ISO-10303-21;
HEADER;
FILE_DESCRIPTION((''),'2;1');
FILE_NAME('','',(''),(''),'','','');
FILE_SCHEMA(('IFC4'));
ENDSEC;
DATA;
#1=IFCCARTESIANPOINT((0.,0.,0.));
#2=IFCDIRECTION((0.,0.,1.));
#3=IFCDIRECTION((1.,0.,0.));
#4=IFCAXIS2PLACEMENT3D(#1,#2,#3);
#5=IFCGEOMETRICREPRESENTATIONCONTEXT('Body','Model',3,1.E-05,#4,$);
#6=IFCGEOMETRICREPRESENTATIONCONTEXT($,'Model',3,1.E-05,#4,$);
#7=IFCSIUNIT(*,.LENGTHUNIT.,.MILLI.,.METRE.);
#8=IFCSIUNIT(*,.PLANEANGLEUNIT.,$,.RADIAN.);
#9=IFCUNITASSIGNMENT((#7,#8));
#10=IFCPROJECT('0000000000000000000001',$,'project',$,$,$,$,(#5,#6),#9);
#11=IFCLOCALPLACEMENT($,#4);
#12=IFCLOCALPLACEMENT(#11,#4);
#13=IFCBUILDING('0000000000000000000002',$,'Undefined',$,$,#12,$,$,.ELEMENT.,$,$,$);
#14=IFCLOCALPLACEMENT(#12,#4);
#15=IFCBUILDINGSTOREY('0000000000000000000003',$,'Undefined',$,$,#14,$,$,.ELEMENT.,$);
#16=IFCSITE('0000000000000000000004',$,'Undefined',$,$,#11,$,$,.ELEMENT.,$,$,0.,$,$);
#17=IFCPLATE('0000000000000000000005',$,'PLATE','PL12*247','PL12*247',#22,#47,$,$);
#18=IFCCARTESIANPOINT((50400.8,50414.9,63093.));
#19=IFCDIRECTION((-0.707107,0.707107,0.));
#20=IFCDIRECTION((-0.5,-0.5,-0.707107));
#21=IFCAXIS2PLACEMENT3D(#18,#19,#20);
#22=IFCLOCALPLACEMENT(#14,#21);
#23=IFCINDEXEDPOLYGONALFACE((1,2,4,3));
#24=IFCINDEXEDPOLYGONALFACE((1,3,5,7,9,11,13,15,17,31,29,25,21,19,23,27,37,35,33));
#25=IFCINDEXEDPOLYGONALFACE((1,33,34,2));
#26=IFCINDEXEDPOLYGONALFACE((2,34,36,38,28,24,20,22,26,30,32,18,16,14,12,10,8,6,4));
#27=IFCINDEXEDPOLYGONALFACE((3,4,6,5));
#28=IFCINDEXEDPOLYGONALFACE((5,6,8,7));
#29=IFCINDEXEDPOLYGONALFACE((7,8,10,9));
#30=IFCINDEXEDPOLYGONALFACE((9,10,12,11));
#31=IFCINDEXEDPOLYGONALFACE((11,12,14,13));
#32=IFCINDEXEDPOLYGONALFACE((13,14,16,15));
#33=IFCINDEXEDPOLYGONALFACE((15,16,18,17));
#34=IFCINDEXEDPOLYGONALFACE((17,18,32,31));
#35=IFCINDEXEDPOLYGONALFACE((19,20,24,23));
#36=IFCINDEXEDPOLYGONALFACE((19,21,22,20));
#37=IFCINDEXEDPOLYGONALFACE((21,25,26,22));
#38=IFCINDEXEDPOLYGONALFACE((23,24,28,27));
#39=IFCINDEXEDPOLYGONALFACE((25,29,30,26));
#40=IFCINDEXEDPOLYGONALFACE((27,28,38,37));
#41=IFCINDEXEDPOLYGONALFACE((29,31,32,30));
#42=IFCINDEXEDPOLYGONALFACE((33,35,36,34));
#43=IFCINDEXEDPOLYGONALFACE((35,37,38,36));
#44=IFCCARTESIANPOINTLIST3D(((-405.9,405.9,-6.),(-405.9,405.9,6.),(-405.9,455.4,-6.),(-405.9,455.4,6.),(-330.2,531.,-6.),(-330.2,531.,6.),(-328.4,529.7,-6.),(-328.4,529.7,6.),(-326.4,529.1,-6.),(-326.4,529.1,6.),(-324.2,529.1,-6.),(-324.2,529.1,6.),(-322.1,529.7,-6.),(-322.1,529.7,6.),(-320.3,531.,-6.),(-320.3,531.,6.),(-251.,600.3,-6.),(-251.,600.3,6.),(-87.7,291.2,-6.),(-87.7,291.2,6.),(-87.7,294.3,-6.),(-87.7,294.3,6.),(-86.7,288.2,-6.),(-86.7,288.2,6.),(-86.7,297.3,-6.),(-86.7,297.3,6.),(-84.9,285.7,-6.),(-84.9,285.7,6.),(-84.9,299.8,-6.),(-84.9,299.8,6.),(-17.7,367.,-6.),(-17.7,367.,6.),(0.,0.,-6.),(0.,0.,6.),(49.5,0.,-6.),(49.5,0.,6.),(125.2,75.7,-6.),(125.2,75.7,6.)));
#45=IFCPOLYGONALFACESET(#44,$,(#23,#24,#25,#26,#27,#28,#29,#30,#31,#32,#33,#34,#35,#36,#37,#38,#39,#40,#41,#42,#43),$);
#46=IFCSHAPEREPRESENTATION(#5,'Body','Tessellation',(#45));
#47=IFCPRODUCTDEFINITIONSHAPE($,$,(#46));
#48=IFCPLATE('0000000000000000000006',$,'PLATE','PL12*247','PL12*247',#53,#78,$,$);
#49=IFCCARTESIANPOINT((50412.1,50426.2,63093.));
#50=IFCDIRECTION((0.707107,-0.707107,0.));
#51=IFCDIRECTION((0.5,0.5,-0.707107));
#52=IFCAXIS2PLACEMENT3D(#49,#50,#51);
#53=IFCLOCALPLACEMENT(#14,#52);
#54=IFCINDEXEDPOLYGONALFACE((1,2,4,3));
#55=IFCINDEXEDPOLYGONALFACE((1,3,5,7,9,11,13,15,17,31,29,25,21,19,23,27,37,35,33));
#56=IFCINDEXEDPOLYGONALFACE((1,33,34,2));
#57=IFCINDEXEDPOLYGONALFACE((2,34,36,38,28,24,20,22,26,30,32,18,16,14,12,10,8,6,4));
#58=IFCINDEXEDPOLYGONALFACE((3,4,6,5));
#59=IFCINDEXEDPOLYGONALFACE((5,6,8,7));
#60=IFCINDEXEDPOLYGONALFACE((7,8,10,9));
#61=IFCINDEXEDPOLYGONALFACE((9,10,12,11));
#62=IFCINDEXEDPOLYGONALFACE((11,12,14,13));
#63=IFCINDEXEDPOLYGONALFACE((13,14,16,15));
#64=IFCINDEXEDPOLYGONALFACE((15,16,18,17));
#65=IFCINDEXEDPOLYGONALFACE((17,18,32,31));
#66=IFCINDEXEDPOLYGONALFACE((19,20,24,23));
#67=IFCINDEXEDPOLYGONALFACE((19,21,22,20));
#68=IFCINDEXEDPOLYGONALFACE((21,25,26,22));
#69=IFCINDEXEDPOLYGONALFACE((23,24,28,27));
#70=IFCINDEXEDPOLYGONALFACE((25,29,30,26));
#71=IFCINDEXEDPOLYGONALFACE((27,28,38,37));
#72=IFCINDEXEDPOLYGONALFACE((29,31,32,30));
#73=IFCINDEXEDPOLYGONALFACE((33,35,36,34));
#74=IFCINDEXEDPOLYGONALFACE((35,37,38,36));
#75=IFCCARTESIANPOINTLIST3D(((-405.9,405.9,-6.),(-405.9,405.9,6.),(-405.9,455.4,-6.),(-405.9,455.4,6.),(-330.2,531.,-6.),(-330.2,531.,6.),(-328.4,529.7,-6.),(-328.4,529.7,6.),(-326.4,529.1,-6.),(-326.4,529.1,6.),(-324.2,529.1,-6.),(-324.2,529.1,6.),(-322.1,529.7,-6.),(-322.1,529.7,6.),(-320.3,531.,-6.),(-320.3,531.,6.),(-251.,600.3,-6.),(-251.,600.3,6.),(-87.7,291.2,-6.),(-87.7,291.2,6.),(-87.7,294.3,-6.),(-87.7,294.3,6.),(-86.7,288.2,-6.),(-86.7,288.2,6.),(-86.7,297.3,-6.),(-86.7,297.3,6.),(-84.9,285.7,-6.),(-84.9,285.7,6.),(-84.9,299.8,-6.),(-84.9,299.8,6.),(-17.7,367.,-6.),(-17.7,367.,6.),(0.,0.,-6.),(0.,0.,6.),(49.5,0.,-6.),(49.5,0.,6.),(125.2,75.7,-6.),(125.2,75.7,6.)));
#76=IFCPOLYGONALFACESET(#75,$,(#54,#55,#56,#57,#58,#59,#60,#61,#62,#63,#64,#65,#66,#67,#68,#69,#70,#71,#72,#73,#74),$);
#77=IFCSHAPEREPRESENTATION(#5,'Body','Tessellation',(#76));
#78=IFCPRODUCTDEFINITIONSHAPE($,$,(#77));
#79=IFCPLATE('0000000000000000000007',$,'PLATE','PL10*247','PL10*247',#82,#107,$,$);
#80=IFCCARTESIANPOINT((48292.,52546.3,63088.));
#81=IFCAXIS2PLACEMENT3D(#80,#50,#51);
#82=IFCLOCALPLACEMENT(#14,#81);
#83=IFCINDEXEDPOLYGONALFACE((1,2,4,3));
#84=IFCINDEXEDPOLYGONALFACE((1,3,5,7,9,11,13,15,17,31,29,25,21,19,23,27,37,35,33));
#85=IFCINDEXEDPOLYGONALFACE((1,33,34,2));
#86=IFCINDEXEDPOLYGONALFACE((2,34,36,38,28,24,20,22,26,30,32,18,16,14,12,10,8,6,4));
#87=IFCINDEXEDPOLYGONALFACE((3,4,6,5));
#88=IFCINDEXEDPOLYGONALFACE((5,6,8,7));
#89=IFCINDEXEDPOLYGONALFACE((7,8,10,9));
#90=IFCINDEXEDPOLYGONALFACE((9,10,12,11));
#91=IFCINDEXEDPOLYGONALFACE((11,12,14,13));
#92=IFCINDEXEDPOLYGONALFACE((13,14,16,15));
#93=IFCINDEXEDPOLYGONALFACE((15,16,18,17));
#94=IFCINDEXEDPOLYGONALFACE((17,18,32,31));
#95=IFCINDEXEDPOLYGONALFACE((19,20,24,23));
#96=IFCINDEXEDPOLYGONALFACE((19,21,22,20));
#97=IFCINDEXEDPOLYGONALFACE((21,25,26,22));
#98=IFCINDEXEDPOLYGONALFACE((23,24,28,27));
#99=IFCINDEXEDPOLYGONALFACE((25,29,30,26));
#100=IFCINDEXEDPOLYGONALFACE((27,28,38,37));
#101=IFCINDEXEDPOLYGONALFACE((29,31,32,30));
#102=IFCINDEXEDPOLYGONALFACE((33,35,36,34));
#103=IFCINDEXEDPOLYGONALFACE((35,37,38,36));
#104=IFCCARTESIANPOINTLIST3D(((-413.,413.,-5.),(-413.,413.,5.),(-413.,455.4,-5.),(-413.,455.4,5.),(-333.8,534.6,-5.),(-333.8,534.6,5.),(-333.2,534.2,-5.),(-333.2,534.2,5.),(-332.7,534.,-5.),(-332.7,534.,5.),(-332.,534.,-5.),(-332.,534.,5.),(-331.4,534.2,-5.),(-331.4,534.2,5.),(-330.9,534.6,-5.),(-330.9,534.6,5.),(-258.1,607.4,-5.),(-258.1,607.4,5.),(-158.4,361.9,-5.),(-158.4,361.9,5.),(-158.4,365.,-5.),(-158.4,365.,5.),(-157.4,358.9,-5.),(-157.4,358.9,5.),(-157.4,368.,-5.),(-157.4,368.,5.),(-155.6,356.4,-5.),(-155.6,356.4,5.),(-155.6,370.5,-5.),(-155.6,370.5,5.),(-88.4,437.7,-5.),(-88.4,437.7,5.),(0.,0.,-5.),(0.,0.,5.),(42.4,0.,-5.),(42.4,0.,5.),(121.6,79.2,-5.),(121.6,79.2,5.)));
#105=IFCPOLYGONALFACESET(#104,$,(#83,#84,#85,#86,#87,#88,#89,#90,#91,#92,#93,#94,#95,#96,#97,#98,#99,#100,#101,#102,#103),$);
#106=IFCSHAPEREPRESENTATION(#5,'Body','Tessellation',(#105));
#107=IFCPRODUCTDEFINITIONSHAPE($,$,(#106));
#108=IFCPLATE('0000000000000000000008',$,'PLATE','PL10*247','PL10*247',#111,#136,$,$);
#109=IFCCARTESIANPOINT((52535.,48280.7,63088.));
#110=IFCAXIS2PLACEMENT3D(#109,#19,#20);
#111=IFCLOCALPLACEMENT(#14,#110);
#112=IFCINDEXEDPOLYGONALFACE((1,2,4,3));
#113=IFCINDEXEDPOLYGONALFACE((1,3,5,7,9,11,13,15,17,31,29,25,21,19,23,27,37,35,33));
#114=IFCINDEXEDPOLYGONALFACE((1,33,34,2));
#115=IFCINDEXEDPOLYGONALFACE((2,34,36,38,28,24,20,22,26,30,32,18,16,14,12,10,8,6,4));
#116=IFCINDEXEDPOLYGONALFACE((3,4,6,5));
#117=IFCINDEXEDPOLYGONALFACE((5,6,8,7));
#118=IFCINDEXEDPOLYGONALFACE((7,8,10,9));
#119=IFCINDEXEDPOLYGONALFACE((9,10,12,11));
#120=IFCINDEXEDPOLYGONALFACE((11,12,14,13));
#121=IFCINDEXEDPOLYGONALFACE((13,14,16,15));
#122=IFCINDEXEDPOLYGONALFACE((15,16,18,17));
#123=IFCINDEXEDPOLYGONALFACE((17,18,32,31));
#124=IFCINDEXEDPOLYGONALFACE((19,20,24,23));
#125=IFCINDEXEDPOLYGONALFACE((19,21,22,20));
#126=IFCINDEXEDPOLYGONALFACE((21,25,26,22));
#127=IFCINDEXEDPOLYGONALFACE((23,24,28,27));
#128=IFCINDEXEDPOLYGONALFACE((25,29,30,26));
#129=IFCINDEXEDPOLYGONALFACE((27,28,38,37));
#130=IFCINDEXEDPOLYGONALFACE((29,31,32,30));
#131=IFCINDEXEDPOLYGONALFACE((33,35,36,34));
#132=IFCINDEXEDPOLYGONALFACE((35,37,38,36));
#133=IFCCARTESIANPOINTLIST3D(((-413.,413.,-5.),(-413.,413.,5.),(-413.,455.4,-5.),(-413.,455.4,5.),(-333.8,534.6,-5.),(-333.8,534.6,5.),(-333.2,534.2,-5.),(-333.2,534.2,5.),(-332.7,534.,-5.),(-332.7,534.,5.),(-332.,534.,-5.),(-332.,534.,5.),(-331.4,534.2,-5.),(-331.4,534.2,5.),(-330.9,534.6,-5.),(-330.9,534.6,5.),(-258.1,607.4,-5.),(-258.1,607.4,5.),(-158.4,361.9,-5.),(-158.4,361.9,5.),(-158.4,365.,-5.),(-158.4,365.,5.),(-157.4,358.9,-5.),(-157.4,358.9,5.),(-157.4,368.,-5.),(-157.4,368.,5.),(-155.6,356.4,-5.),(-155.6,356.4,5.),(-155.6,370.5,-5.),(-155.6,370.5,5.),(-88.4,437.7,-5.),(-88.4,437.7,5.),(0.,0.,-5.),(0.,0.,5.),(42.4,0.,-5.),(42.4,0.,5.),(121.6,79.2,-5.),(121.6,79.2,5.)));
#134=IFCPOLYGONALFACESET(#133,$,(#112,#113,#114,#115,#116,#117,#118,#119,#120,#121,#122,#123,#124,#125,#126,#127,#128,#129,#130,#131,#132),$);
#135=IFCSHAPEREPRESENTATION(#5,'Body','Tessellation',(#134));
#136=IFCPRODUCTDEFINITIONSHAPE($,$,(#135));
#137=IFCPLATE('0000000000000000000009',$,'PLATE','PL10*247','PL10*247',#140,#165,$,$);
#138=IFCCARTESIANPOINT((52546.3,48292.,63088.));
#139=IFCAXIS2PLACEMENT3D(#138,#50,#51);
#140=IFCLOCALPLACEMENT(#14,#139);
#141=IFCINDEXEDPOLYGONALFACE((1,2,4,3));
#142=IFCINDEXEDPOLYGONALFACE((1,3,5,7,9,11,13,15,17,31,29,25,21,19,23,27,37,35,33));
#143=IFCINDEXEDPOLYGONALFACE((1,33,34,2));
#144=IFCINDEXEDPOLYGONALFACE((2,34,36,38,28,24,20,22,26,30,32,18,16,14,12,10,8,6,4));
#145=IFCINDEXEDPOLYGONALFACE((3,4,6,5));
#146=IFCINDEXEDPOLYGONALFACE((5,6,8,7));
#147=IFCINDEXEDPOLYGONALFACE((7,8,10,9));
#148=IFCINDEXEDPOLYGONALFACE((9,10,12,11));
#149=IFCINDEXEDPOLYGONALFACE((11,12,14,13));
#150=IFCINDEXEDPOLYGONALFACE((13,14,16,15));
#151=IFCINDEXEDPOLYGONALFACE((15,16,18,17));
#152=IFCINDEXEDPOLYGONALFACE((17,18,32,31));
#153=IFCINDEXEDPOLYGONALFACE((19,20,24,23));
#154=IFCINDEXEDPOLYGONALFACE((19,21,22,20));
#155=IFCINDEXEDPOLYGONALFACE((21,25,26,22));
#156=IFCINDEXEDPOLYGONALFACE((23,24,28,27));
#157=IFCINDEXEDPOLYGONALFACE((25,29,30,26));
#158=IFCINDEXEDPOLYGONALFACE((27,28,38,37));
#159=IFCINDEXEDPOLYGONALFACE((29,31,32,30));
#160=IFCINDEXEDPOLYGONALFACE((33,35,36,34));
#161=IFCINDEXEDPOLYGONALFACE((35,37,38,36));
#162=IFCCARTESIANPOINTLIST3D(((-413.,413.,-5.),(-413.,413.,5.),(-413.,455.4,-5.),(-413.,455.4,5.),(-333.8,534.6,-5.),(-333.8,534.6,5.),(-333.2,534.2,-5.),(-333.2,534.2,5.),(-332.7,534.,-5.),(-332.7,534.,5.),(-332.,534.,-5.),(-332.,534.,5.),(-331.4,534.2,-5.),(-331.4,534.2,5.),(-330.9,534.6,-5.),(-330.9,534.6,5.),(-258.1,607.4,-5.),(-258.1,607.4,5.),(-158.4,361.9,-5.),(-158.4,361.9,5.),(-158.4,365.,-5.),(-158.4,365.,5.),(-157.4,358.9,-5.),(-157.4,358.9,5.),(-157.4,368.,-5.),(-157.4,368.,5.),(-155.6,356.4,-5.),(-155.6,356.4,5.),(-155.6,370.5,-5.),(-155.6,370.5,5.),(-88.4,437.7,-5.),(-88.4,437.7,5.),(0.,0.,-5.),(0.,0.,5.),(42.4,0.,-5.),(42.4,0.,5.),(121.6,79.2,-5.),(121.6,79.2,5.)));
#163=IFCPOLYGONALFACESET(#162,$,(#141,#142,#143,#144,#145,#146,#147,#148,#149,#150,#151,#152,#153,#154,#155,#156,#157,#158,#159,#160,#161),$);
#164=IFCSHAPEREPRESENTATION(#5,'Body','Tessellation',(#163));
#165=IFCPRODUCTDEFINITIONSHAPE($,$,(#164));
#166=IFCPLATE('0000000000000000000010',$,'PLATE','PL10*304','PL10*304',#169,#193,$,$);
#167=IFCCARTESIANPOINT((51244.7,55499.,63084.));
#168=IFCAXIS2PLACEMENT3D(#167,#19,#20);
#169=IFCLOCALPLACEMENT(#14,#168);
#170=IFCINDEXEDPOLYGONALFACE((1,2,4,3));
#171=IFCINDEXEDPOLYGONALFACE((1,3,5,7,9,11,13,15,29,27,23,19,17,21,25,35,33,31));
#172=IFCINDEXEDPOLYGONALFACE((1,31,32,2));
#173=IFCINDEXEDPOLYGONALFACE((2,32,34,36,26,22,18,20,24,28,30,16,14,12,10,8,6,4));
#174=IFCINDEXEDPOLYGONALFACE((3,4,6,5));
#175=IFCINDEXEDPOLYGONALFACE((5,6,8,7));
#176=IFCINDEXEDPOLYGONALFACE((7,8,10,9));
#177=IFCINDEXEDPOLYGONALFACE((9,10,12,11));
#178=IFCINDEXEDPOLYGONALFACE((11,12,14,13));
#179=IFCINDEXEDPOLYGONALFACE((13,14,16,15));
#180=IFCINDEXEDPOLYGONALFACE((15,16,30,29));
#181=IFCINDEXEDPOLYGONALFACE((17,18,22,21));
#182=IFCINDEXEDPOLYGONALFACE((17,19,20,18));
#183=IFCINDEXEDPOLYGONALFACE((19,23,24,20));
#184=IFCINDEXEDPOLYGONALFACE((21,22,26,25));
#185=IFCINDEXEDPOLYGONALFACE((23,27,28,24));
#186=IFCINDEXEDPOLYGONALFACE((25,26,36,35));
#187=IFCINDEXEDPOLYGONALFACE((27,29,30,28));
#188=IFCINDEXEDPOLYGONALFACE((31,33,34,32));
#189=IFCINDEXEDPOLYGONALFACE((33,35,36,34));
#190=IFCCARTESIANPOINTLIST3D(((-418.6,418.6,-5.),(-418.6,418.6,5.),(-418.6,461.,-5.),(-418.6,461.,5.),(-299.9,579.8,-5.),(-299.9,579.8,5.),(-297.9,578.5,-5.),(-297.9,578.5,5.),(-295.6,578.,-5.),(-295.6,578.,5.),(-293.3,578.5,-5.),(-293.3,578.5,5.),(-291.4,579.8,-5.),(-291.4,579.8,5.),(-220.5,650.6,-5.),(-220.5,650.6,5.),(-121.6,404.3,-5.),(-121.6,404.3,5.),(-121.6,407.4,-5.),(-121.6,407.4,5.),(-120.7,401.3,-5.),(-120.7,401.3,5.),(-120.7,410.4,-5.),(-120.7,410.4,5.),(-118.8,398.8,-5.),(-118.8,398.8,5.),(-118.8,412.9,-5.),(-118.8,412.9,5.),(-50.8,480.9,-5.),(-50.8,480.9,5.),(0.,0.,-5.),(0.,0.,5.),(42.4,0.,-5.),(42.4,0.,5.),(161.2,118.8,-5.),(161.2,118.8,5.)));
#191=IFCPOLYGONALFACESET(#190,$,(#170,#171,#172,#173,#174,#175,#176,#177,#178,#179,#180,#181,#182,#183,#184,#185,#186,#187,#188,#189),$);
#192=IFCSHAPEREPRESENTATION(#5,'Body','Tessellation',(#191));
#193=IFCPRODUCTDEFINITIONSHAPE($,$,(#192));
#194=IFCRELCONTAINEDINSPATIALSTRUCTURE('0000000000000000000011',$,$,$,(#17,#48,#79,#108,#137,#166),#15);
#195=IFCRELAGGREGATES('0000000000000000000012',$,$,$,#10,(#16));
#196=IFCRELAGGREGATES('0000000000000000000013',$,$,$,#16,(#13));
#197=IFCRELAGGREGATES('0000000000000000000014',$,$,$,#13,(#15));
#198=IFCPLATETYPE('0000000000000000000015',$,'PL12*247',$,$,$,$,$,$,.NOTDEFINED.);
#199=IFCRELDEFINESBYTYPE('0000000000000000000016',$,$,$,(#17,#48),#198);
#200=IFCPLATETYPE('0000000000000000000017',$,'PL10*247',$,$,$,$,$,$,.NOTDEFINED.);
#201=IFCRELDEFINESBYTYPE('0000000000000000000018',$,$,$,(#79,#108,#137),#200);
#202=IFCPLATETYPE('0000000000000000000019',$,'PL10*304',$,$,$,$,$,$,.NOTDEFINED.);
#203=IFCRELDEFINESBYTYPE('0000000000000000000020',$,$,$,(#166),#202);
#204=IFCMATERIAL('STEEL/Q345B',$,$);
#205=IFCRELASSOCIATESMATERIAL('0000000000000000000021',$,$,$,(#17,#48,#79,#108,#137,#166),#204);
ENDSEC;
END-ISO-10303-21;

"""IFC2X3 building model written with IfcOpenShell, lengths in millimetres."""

from ifc_helpers import new_model, si_unit, frame, origin_with_axes, place, context, project, spatial, polyline, outline, extrude, material, type_object, element, save


model = new_model("IFC2X3")

# Units and contexts
model_context_1 = context("Model", 3, precision=1e-05, world=origin_with_axes(), identifier="Body")
model_context_2 = context("Model", 3, precision=1e-05, world=origin_with_axes())
ifc_project = project(units=[si_unit("LENGTHUNIT", "METRE", prefix="MILLI"), si_unit("PLANEANGLEUNIT", "RADIAN")], contexts=[model_context_1, model_context_2])

# Site, building, storey
site_placement = place(None, origin_with_axes())
site = spatial("IfcSite", under=ifc_project, at=site_placement, Name="Undefined", CompositionType="ELEMENT", RefElevation=0.0)
building_placement = place(site_placement, origin_with_axes())
building = spatial("IfcBuilding", under=site, at=building_placement, Name="Undefined", CompositionType="ELEMENT")
storey_placement = place(building_placement, origin_with_axes())
storey = spatial("IfcBuildingStorey", under=building, at=storey_placement, Name="Undefined", CompositionType="ELEMENT")

# Shared definitions
ifc_material_1 = material(Name="STEEL/Q345B")

# Plates
plate_type_1 = type_object("IfcPlateType", Name="PL12*247", PredefinedType="NOTDEFINED")
for number, where, z_axis, x_axis, name in (
    (1, (50400.8, 50414.9, 63093.0), (-0.707107, 0.707107, 0.0), (-0.5, -0.5, -0.707107), "PLATE"),
    (2, (50412.1, 50426.2, 63093.0), (0.707107, -0.707107, 0.0), (0.5, 0.5, -0.707107), "PLATE"),
):
    element("IfcPlate", number, at=place(storey_placement, frame(where, z_axis=z_axis, x_axis=x_axis)), inside=storey, type_object=plate_type_1, material=ifc_material_1, Name=name, Description="PL12*247", ObjectType="PL12*247", context=model_context_1, shape_type="SweptSolid", body=[
        extrude(outline(polyline([(0.0, 0.0), (49.5, 0.0), (125.2, 75.7), (-84.9, 285.7), (-86.7, 288.2), (-87.7, 291.2), (-87.7, 294.3), (-86.7, 297.3), (-84.9, 299.8), (-17.7, 367.0), (-251.0, 600.3), (-320.3, 531.0), (-322.1, 529.7), (-324.2, 529.1), (-326.4, 529.1), (-328.4, 529.7), (-330.2, 531.0), (-405.9, 455.4), (-405.9, 405.9), (0.0, 0.0)])), frame((0.0, 0.0, -6.0), z_axis=(0.0, 0.0, 1.0), x_axis=(1.0, 0.0, 0.0)), (0.0, 0.0, 1.0), 12.0),
    ])
plate_type_2 = type_object("IfcPlateType", Name="PL10*247", PredefinedType="NOTDEFINED")
plate_1_placement = place(storey_placement, frame((48292.0, 52546.3, 63088.0), z_axis=(0.707107, -0.707107, 0.0), x_axis=(0.5, 0.5, -0.707107)))
element("IfcPlate", 3, at=plate_1_placement, inside=storey, type_object=plate_type_2, material=ifc_material_1, Name="PLATE", Description="PL10*247", ObjectType="PL10*247", context=model_context_1, shape_type="SweptSolid", body=[
    extrude(outline(polyline([(0.0, 0.0), (42.4, 0.0), (121.6, 79.2), (-155.6, 356.4), (-157.4, 358.9), (-158.4, 361.9), (-158.4, 365.0), (-157.4, 368.0), (-155.6, 370.5), (-88.4, 437.7), (-258.1, 607.4), (-330.9, 534.6), (-331.4, 534.2), (-332.0, 534.0), (-332.7, 534.0), (-333.2, 534.2), (-333.8, 534.6), (-413.0, 455.4), (-413.0, 413.0), (0.0, 0.0)])), frame((0.0, 0.0, -5.0), z_axis=(0.0, 0.0, 1.0), x_axis=(1.0, 0.0, 0.0)), (0.0, 0.0, 1.0), 10.0),
])
plate_2_placement = place(storey_placement, frame((52535.0, 48280.7, 63088.0), z_axis=(-0.707107, 0.707107, 0.0), x_axis=(-0.5, -0.5, -0.707107)))
element("IfcPlate", 4, at=plate_2_placement, inside=storey, type_object=plate_type_2, material=ifc_material_1, Name="PLATE", Description="PL10*247", ObjectType="PL10*247", context=model_context_1, shape_type="SweptSolid", body=[
    extrude(outline(polyline([(0.0, 0.0), (42.4, 0.0), (121.6, 79.2), (-155.6, 356.4), (-157.4, 358.9), (-158.4, 361.9), (-158.4, 365.0), (-157.4, 368.0), (-155.6, 370.5), (-88.4, 437.7), (-258.1, 607.4), (-330.9, 534.6), (-331.4, 534.2), (-332.0, 534.0), (-332.7, 534.0), (-333.2, 534.2), (-333.8, 534.6), (-413.0, 455.4), (-413.0, 413.0), (0.0, 0.0)])), frame((0.0, 0.0, -5.0), z_axis=(0.0, 0.0, 1.0), x_axis=(1.0, 0.0, 0.0)), (0.0, 0.0, 1.0), 10.0),
])
plate_3_placement = place(storey_placement, frame((52546.3, 48292.0, 63088.0), z_axis=(0.707107, -0.707107, 0.0), x_axis=(0.5, 0.5, -0.707107)))
element("IfcPlate", 5, at=plate_3_placement, inside=storey, type_object=plate_type_2, material=ifc_material_1, Name="PLATE", Description="PL10*247", ObjectType="PL10*247", context=model_context_1, shape_type="SweptSolid", body=[
    extrude(outline(polyline([(0.0, 0.0), (42.4, 0.0), (121.6, 79.2), (-155.6, 356.4), (-157.4, 358.9), (-158.4, 361.9), (-158.4, 365.0), (-157.4, 368.0), (-155.6, 370.5), (-88.4, 437.7), (-258.1, 607.4), (-330.9, 534.6), (-331.4, 534.2), (-332.0, 534.0), (-332.7, 534.0), (-333.2, 534.2), (-333.8, 534.6), (-413.0, 455.4), (-413.0, 413.0), (0.0, 0.0)])), frame((0.0, 0.0, -5.0), z_axis=(0.0, 0.0, 1.0), x_axis=(1.0, 0.0, 0.0)), (0.0, 0.0, 1.0), 10.0),
])
plate_type_3 = type_object("IfcPlateType", Name="PL10*304", PredefinedType="NOTDEFINED")
plate_4_placement = place(storey_placement, frame((51244.7, 55499.0, 63084.0), z_axis=(-0.707107, 0.707107, 0.0), x_axis=(-0.5, -0.5, -0.707107)))
element("IfcPlate", 6, at=plate_4_placement, inside=storey, type_object=plate_type_3, material=ifc_material_1, Name="PLATE", Description="PL10*304", ObjectType="PL10*304", context=model_context_1, shape_type="SweptSolid", body=[
    extrude(outline(polyline([(0.0, 0.0), (42.4, 0.0), (161.2, 118.8), (-118.8, 398.8), (-120.7, 401.3), (-121.6, 404.3), (-121.6, 407.4), (-120.7, 410.4), (-118.8, 412.9), (-50.8, 480.9), (-220.5, 650.6), (-291.4, 579.8), (-293.3, 578.5), (-295.6, 578.0), (-297.9, 578.5), (-299.9, 579.8), (-418.6, 461.0), (-418.6, 418.6), (0.0, 0.0)])), frame((0.0, 0.0, -5.0), z_axis=(0.0, 0.0, 1.0), x_axis=(1.0, 0.0, 0.0)), (0.0, 0.0, 1.0), 10.0),
])

save(model, "model.ifc")
